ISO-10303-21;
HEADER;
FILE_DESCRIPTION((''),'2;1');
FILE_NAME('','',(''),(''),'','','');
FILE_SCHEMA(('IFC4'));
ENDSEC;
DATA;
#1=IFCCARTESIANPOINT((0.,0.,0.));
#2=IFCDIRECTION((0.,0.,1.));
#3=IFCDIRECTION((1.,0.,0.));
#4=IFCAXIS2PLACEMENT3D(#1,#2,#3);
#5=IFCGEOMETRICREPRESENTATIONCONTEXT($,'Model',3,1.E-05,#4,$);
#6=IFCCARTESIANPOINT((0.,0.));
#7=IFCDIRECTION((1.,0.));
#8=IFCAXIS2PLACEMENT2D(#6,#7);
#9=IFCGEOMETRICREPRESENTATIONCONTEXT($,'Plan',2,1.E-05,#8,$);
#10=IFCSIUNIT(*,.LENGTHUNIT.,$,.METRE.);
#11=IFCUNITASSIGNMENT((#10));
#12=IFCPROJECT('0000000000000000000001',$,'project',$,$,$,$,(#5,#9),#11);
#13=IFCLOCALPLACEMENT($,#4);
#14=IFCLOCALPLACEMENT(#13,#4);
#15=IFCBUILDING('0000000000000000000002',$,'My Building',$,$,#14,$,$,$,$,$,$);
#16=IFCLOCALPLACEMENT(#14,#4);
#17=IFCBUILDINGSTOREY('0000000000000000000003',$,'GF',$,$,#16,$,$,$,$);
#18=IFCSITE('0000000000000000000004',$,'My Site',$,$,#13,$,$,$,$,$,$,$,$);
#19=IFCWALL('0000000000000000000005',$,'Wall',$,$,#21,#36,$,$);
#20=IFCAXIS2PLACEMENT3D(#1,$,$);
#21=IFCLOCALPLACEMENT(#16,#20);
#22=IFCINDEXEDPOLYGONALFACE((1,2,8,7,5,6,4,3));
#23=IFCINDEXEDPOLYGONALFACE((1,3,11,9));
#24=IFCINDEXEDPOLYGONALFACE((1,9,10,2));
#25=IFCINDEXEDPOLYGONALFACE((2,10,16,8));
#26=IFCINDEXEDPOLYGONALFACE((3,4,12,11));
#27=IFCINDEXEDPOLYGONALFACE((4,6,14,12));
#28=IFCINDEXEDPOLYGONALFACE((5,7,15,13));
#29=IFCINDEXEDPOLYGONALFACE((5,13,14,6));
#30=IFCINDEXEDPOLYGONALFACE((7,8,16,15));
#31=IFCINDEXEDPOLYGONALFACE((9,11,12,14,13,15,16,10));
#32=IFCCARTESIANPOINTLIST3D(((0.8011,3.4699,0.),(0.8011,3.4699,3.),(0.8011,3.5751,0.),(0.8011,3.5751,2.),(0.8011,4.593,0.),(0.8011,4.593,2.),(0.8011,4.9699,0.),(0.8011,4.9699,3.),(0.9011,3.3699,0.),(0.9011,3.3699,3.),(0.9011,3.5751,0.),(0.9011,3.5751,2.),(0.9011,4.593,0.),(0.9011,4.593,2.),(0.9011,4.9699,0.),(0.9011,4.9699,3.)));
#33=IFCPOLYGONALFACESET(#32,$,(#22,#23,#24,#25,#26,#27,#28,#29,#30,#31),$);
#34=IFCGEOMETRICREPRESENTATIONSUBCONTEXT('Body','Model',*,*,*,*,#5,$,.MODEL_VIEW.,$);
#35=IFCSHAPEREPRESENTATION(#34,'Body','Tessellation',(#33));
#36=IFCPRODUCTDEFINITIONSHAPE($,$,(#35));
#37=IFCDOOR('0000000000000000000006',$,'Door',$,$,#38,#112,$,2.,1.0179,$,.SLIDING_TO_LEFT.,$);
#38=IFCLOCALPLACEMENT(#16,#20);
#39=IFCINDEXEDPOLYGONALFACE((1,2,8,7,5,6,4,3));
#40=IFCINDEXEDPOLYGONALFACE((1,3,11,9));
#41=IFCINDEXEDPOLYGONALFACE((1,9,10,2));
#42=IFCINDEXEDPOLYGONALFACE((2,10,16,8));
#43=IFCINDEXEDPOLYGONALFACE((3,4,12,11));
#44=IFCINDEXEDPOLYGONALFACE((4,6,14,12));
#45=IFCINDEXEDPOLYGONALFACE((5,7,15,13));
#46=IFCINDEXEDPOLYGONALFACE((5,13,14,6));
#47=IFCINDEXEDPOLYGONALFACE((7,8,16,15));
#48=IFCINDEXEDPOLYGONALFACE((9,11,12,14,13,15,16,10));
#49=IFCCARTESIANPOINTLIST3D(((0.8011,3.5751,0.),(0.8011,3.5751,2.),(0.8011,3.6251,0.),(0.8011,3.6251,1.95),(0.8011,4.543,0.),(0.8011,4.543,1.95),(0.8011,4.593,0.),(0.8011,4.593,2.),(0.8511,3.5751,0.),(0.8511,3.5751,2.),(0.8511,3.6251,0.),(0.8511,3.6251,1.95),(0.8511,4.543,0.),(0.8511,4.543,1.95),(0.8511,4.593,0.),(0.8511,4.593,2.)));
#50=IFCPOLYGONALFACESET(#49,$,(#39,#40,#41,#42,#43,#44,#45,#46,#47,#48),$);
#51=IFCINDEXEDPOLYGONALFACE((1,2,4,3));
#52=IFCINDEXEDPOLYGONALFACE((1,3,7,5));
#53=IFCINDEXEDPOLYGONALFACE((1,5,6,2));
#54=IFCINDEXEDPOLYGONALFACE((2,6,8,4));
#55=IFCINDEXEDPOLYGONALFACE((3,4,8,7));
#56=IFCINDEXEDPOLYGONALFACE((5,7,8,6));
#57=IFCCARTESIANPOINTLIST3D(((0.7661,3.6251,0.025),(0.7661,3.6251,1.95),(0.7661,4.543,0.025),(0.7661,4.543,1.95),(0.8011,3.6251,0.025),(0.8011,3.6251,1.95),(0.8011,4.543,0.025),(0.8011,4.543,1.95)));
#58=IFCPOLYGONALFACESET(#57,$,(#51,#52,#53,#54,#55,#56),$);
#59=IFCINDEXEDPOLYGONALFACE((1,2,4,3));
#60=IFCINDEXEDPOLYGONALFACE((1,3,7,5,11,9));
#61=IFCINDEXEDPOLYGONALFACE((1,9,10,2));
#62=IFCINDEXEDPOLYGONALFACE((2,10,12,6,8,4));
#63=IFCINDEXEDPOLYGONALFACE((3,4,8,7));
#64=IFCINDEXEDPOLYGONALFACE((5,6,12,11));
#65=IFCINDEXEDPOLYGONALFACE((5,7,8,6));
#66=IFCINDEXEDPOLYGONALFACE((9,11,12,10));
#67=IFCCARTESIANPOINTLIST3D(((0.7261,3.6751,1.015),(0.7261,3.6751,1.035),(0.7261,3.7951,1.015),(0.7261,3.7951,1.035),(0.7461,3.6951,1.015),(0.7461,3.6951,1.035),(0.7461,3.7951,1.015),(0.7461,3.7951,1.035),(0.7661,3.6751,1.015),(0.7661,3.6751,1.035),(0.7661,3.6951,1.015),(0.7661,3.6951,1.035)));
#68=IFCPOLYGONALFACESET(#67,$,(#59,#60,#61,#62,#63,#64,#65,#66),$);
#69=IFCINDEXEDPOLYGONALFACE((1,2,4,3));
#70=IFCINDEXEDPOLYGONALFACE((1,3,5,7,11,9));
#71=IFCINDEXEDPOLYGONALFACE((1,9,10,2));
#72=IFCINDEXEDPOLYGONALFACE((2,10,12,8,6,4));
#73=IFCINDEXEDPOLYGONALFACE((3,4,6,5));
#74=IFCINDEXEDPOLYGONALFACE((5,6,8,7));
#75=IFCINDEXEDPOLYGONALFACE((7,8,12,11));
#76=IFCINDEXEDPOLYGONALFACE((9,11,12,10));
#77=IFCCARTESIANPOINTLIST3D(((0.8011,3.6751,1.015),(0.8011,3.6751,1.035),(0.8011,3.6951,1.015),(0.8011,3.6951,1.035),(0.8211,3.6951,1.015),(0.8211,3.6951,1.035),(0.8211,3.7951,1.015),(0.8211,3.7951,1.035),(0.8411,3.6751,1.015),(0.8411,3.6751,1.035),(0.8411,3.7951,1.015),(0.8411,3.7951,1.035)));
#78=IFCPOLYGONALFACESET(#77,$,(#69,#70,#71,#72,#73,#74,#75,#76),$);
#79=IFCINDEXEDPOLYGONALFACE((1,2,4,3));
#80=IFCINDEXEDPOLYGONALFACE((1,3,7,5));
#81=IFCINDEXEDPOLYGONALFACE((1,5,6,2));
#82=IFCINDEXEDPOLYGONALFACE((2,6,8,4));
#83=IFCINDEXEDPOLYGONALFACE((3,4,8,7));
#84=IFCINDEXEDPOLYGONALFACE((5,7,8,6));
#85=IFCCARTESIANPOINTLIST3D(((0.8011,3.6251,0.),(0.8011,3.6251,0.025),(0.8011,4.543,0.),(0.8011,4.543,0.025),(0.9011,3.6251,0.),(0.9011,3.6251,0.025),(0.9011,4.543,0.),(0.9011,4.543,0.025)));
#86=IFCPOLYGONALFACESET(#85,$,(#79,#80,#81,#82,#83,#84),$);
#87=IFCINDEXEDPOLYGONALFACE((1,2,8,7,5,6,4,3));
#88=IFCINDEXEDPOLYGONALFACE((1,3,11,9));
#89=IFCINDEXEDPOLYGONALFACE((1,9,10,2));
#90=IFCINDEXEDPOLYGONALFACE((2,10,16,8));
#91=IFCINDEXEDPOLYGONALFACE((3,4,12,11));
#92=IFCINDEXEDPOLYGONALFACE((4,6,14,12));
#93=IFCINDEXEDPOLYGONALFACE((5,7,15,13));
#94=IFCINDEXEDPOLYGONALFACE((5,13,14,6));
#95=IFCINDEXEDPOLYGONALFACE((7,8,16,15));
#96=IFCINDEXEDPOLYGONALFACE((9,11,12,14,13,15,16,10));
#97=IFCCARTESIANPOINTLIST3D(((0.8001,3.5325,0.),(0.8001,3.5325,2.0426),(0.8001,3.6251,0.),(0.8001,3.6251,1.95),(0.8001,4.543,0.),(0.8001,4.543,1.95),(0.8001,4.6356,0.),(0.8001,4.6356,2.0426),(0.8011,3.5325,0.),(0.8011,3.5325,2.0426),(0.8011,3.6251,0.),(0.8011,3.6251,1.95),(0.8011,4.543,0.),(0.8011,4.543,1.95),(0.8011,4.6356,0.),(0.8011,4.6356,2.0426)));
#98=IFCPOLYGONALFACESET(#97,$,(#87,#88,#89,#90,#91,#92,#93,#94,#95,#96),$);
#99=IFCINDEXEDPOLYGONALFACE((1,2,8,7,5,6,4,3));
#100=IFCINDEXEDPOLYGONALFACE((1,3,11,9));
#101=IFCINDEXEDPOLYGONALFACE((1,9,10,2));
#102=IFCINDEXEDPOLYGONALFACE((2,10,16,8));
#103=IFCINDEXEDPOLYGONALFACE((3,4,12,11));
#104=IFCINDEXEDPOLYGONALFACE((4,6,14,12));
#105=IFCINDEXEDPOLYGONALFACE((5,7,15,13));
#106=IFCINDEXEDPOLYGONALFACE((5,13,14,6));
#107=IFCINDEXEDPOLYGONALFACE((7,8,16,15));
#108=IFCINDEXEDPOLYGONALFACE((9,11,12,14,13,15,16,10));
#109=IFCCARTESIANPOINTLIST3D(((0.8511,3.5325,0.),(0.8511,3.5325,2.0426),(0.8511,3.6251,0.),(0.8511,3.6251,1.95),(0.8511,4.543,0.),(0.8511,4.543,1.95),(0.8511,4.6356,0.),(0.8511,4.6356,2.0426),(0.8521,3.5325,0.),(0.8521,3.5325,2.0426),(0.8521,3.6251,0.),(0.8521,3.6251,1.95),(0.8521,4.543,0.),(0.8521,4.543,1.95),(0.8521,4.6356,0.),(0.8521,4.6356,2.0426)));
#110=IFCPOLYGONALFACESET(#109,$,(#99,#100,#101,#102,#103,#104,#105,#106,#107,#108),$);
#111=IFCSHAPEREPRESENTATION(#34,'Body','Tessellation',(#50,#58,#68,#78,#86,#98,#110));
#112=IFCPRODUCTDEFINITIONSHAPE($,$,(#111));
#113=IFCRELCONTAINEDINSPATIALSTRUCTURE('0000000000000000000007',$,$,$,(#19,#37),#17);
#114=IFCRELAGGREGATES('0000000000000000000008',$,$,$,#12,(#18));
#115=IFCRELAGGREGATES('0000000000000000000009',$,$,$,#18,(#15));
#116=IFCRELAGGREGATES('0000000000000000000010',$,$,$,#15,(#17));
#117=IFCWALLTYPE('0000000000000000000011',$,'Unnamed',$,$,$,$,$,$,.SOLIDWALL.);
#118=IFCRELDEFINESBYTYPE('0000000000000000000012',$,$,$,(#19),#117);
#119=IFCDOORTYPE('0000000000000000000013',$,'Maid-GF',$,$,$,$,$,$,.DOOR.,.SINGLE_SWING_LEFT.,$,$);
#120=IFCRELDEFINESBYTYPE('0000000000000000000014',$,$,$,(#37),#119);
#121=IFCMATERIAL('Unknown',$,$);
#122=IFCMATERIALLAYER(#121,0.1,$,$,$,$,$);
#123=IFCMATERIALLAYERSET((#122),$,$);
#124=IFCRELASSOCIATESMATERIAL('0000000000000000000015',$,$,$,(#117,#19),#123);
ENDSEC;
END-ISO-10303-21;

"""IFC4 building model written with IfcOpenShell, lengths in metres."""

from ifc_helpers import new_model, entity, si_unit, frame, origin_with_axes, origin_2d_with_axis, place, context, subcontext, project, spatial, line, indexed_curve, outline, extrude, shape, source, transform, mapped, material, layer, layer_set, layer_usage, type_object, type_shapes, element, fill, save


model = new_model("IFC4")

# Units and contexts
model_context = context("Model", 3, precision=1e-05, world=origin_with_axes())
plan_context = context("Plan", 2, precision=1e-05, world=origin_2d_with_axis())
body_context_1 = subcontext(model_context, "Body", "Model", "MODEL_VIEW")
body_context_2 = subcontext(plan_context, "Body", "Plan", "PLAN_VIEW")
ifc_project = project(units=[si_unit("LENGTHUNIT", "METRE")], contexts=[model_context, plan_context])

# Site, building, storey
site_placement = place(None, origin_with_axes())
site = spatial("IfcSite", under=ifc_project, at=site_placement, Name="My Site")
building_placement = place(site_placement, origin_with_axes())
building = spatial("IfcBuilding", under=site, at=building_placement, Name="My Building")
storey_placement = place(building_placement, origin_with_axes())
storey = spatial("IfcBuildingStorey", under=building, at=storey_placement, Name="GF")

# Shared definitions
ifc_material = material(Name="Unknown")

# Shared definitions
ifc_layer_1 = layer(ifc_material, 0.1)
ifc_layer_set_1 = layer_set([ifc_layer_1])
wall_type = type_object("IfcWallType", Name="Unnamed", PredefinedType="SOLIDWALL", material=ifc_layer_set_1)

# Wall, opening, door
ifc_layer_usage_1 = layer_usage(ifc_layer_set_1, "AXIS2", "POSITIVE", 0.0)
wall_1_placement = place(storey_placement, frame((0.8011, 4.9699, 0.0), z_axis=(0.0, 0.0, 1.0), x_axis=(0.0, -1.0, 0.0)))
wall_1 = element("IfcWall", 1, at=wall_1_placement, inside=storey, type_object=wall_type, material=ifc_layer_usage_1, Name="Wall", context=body_context_1, shape_type="SweptSolid", body=[
    extrude(outline(indexed_curve([(0.0, 0.0), (0.0, 0.1), (1.6, 0.1), (1.5, 0.0)], segments=[line(1, 2, 3, 4, 1)])), origin_with_axes(), (0.0, 0.0, 1.0), 3.0),
])
shared_shape_1 = source(origin_with_axes(), body_context_1, "Body", "SweptSolid", [
    extrude(outline(indexed_curve([(0.0, 0.0), (1.0179, 0.0), (1.0179, 2.0), (0.0, 2.0)], segments=[line(1, 2, 3, 4, 1)])), frame((0.0, -0.6, 0.0), z_axis=(0.0, -1.0, 0.0), x_axis=(1.0, 0.0, 0.0)), (0.0, 0.0, -1.0), 1.2),
])
opening_1_placement = place(wall_1_placement, frame((0.3769, 0.0, 0.0), z_axis=(0.0, 0.0, 1.0), x_axis=(1.0, 0.0, 0.0)))
opening_1 = element("IfcOpeningElement", 2, at=opening_1_placement, cuts=wall_1, PredefinedType="OPENING", context=body_context_1, shape_type="MappedRepresentation", body=[
    mapped(shared_shape_1, transform((0.0, 0.0, 0.0), x_axis=(1.0, 0.0, 0.0), y_axis=(0.0, 1.0, 0.0), z_axis=(0.0, 0.0, 1.0), scale=1.0)),
])
door_type_1 = type_object("IfcDoorType", Name="Maid-GF", OperationType="SINGLE_SWING_LEFT", PredefinedType="DOOR")
shared_shape_2 = source(origin_with_axes(), body_context_1, "Body", "SweptSolid", [
    extrude(outline(indexed_curve([(0.0, 0.0), (0.0, 2.0), (1.0179, 2.0), (1.0179, 0.0), (0.9679, 0.0), (0.9679, 1.95), (0.05, 1.95), (0.05, 0.0)], segments=[line(1, 2, 3, 4, 5, 6, 7, 8, 1)])), frame((0.0, 0.0, 0.0), z_axis=(0.0, -1.0, 0.0), x_axis=(1.0, 0.0, 0.0)), (0.0, 0.0, -1.0), 0.05),
    extrude(outline(indexed_curve([(0.0, 0.0), (0.9179, 0.0), (0.9179, 0.035), (0.0, 0.035)], segments=[line(1, 2, 3, 4, 1)])), frame((0.05, -0.035, 0.025), z_axis=(0.0, 0.0, 1.0), x_axis=(1.0, 0.0, 0.0)), (0.0, 0.0, 1.0), 1.925),
    extrude(outline(indexed_curve([(0.0, 0.0), (0.0, -0.04), (-0.12, -0.04), (-0.12, -0.02), (-0.02, -0.02), (-0.02, 0.0)], segments=[line(1, 2, 3, 4, 5, 6, 1)])), frame((0.9179, -0.035, 1.015), z_axis=(0.0, 0.0, 1.0), x_axis=(1.0, 0.0, 0.0)), (0.0, 0.0, 1.0), 0.02),
    extrude(outline(indexed_curve([(0.0, 0.0), (0.0, 0.04), (-0.12, 0.04), (-0.12, 0.02), (-0.02, 0.02), (-0.02, 0.0)], segments=[line(1, 2, 3, 4, 5, 6, 1)])), frame((0.9179, 0.0, 1.015), z_axis=(0.0, 0.0, 1.0), x_axis=(1.0, 0.0, 0.0)), (0.0, 0.0, 1.0), 0.02),
    extrude(outline(indexed_curve([(0.0, 0.0), (0.9179, 0.0), (0.9179, 0.1), (0.0, 0.1)], segments=[line(1, 2, 3, 4, 1)])), frame((0.05, 0.0, 0.0), z_axis=(0.0, 0.0, 1.0), x_axis=(1.0, 0.0, 0.0)), (0.0, 0.0, 1.0), 0.025),
    extrude(outline(indexed_curve([(0.0, 0.0), (0.0, 2.0426), (1.1031, 2.0426), (1.1031, 0.0), (1.0105, 0.0), (1.0105, 1.95), (0.0926, 1.95), (0.0926, 0.0)], segments=[line(1, 2, 3, 4, 5, 6, 7, 8, 1)])), frame((-0.0426, -0.001, 0.0), z_axis=(0.0, -1.0, 0.0), x_axis=(1.0, 0.0, 0.0)), (0.0, 0.0, -1.0), 0.001),
    extrude(outline(indexed_curve([(0.0, 0.0), (0.0, 2.0426), (1.1031, 2.0426), (1.1031, 0.0), (1.0105, 0.0), (1.0105, 1.95), (0.0926, 1.95), (0.0926, 0.0)], segments=[line(1, 2, 3, 4, 5, 6, 7, 8, 1)])), frame((-0.0426, 0.05, 0.0), z_axis=(0.0, -1.0, 0.0), x_axis=(1.0, 0.0, 0.0)), (0.0, 0.0, -1.0), 0.001),
])
shared_shape_3 = source(origin_with_axes(), body_context_2, "Body", "Curve2D", [
    entity("IfcIndexedPolyCurve", entity("IfcCartesianPointList2D", [[0.0, 0.0], [0.05, 0.0], [0.05, 0.05], [0.0, 0.05]]), [entity("IfcLineIndex", [1, 2, 3, 4, 1])]),
    entity("IfcIndexedPolyCurve", entity("IfcCartesianPointList2D", [[1.0179, 0.0], [0.9679, 0.0], [0.9679, 0.05], [1.0179, 0.05]]), [entity("IfcLineIndex", [1, 2, 3, 4, 1])]),
    entity("IfcIndexedPolyCurve", entity("IfcCartesianPointList2D", [[-0.4089, -0.035], [0.5089, -0.035], [0.5089, 0.0], [-0.4089, 0.0]]), [entity("IfcLineIndex", [1, 2, 3, 4, 1])]),
])
type_shapes(door_type_1, [shared_shape_2, shared_shape_3])
door_1_placement = place(opening_1_placement, frame((0.0, 0.0, 0.0), z_axis=(0.0, 0.0, 1.0), x_axis=(1.0, 0.0, 0.0)))
door_1 = element("IfcDoor", 3, at=door_1_placement, inside=storey, type_object=door_type_1, Name="Door", OperationType="SLIDING_TO_LEFT", OverallHeight=2.0, OverallWidth=1.0179, shapes=[
    shape(body_context_1, "Body", "MappedRepresentation", [mapped(shared_shape_2, transform((0.0, 0.0, 0.0), x_axis=(1.0, 0.0, 0.0), y_axis=(0.0, 1.0, 0.0), z_axis=(0.0, 0.0, 1.0), scale=1.0))]),
    shape(body_context_2, "Body", "MappedRepresentation", [mapped(shared_shape_3, transform((0.0, 0.0, 0.0), x_axis=(1.0, 0.0, 0.0), y_axis=(0.0, 1.0, 0.0), z_axis=(0.0, 0.0, 1.0), scale=1.0))]),
])
fill(opening_1, door_1)

save(model, "model.ifc")
